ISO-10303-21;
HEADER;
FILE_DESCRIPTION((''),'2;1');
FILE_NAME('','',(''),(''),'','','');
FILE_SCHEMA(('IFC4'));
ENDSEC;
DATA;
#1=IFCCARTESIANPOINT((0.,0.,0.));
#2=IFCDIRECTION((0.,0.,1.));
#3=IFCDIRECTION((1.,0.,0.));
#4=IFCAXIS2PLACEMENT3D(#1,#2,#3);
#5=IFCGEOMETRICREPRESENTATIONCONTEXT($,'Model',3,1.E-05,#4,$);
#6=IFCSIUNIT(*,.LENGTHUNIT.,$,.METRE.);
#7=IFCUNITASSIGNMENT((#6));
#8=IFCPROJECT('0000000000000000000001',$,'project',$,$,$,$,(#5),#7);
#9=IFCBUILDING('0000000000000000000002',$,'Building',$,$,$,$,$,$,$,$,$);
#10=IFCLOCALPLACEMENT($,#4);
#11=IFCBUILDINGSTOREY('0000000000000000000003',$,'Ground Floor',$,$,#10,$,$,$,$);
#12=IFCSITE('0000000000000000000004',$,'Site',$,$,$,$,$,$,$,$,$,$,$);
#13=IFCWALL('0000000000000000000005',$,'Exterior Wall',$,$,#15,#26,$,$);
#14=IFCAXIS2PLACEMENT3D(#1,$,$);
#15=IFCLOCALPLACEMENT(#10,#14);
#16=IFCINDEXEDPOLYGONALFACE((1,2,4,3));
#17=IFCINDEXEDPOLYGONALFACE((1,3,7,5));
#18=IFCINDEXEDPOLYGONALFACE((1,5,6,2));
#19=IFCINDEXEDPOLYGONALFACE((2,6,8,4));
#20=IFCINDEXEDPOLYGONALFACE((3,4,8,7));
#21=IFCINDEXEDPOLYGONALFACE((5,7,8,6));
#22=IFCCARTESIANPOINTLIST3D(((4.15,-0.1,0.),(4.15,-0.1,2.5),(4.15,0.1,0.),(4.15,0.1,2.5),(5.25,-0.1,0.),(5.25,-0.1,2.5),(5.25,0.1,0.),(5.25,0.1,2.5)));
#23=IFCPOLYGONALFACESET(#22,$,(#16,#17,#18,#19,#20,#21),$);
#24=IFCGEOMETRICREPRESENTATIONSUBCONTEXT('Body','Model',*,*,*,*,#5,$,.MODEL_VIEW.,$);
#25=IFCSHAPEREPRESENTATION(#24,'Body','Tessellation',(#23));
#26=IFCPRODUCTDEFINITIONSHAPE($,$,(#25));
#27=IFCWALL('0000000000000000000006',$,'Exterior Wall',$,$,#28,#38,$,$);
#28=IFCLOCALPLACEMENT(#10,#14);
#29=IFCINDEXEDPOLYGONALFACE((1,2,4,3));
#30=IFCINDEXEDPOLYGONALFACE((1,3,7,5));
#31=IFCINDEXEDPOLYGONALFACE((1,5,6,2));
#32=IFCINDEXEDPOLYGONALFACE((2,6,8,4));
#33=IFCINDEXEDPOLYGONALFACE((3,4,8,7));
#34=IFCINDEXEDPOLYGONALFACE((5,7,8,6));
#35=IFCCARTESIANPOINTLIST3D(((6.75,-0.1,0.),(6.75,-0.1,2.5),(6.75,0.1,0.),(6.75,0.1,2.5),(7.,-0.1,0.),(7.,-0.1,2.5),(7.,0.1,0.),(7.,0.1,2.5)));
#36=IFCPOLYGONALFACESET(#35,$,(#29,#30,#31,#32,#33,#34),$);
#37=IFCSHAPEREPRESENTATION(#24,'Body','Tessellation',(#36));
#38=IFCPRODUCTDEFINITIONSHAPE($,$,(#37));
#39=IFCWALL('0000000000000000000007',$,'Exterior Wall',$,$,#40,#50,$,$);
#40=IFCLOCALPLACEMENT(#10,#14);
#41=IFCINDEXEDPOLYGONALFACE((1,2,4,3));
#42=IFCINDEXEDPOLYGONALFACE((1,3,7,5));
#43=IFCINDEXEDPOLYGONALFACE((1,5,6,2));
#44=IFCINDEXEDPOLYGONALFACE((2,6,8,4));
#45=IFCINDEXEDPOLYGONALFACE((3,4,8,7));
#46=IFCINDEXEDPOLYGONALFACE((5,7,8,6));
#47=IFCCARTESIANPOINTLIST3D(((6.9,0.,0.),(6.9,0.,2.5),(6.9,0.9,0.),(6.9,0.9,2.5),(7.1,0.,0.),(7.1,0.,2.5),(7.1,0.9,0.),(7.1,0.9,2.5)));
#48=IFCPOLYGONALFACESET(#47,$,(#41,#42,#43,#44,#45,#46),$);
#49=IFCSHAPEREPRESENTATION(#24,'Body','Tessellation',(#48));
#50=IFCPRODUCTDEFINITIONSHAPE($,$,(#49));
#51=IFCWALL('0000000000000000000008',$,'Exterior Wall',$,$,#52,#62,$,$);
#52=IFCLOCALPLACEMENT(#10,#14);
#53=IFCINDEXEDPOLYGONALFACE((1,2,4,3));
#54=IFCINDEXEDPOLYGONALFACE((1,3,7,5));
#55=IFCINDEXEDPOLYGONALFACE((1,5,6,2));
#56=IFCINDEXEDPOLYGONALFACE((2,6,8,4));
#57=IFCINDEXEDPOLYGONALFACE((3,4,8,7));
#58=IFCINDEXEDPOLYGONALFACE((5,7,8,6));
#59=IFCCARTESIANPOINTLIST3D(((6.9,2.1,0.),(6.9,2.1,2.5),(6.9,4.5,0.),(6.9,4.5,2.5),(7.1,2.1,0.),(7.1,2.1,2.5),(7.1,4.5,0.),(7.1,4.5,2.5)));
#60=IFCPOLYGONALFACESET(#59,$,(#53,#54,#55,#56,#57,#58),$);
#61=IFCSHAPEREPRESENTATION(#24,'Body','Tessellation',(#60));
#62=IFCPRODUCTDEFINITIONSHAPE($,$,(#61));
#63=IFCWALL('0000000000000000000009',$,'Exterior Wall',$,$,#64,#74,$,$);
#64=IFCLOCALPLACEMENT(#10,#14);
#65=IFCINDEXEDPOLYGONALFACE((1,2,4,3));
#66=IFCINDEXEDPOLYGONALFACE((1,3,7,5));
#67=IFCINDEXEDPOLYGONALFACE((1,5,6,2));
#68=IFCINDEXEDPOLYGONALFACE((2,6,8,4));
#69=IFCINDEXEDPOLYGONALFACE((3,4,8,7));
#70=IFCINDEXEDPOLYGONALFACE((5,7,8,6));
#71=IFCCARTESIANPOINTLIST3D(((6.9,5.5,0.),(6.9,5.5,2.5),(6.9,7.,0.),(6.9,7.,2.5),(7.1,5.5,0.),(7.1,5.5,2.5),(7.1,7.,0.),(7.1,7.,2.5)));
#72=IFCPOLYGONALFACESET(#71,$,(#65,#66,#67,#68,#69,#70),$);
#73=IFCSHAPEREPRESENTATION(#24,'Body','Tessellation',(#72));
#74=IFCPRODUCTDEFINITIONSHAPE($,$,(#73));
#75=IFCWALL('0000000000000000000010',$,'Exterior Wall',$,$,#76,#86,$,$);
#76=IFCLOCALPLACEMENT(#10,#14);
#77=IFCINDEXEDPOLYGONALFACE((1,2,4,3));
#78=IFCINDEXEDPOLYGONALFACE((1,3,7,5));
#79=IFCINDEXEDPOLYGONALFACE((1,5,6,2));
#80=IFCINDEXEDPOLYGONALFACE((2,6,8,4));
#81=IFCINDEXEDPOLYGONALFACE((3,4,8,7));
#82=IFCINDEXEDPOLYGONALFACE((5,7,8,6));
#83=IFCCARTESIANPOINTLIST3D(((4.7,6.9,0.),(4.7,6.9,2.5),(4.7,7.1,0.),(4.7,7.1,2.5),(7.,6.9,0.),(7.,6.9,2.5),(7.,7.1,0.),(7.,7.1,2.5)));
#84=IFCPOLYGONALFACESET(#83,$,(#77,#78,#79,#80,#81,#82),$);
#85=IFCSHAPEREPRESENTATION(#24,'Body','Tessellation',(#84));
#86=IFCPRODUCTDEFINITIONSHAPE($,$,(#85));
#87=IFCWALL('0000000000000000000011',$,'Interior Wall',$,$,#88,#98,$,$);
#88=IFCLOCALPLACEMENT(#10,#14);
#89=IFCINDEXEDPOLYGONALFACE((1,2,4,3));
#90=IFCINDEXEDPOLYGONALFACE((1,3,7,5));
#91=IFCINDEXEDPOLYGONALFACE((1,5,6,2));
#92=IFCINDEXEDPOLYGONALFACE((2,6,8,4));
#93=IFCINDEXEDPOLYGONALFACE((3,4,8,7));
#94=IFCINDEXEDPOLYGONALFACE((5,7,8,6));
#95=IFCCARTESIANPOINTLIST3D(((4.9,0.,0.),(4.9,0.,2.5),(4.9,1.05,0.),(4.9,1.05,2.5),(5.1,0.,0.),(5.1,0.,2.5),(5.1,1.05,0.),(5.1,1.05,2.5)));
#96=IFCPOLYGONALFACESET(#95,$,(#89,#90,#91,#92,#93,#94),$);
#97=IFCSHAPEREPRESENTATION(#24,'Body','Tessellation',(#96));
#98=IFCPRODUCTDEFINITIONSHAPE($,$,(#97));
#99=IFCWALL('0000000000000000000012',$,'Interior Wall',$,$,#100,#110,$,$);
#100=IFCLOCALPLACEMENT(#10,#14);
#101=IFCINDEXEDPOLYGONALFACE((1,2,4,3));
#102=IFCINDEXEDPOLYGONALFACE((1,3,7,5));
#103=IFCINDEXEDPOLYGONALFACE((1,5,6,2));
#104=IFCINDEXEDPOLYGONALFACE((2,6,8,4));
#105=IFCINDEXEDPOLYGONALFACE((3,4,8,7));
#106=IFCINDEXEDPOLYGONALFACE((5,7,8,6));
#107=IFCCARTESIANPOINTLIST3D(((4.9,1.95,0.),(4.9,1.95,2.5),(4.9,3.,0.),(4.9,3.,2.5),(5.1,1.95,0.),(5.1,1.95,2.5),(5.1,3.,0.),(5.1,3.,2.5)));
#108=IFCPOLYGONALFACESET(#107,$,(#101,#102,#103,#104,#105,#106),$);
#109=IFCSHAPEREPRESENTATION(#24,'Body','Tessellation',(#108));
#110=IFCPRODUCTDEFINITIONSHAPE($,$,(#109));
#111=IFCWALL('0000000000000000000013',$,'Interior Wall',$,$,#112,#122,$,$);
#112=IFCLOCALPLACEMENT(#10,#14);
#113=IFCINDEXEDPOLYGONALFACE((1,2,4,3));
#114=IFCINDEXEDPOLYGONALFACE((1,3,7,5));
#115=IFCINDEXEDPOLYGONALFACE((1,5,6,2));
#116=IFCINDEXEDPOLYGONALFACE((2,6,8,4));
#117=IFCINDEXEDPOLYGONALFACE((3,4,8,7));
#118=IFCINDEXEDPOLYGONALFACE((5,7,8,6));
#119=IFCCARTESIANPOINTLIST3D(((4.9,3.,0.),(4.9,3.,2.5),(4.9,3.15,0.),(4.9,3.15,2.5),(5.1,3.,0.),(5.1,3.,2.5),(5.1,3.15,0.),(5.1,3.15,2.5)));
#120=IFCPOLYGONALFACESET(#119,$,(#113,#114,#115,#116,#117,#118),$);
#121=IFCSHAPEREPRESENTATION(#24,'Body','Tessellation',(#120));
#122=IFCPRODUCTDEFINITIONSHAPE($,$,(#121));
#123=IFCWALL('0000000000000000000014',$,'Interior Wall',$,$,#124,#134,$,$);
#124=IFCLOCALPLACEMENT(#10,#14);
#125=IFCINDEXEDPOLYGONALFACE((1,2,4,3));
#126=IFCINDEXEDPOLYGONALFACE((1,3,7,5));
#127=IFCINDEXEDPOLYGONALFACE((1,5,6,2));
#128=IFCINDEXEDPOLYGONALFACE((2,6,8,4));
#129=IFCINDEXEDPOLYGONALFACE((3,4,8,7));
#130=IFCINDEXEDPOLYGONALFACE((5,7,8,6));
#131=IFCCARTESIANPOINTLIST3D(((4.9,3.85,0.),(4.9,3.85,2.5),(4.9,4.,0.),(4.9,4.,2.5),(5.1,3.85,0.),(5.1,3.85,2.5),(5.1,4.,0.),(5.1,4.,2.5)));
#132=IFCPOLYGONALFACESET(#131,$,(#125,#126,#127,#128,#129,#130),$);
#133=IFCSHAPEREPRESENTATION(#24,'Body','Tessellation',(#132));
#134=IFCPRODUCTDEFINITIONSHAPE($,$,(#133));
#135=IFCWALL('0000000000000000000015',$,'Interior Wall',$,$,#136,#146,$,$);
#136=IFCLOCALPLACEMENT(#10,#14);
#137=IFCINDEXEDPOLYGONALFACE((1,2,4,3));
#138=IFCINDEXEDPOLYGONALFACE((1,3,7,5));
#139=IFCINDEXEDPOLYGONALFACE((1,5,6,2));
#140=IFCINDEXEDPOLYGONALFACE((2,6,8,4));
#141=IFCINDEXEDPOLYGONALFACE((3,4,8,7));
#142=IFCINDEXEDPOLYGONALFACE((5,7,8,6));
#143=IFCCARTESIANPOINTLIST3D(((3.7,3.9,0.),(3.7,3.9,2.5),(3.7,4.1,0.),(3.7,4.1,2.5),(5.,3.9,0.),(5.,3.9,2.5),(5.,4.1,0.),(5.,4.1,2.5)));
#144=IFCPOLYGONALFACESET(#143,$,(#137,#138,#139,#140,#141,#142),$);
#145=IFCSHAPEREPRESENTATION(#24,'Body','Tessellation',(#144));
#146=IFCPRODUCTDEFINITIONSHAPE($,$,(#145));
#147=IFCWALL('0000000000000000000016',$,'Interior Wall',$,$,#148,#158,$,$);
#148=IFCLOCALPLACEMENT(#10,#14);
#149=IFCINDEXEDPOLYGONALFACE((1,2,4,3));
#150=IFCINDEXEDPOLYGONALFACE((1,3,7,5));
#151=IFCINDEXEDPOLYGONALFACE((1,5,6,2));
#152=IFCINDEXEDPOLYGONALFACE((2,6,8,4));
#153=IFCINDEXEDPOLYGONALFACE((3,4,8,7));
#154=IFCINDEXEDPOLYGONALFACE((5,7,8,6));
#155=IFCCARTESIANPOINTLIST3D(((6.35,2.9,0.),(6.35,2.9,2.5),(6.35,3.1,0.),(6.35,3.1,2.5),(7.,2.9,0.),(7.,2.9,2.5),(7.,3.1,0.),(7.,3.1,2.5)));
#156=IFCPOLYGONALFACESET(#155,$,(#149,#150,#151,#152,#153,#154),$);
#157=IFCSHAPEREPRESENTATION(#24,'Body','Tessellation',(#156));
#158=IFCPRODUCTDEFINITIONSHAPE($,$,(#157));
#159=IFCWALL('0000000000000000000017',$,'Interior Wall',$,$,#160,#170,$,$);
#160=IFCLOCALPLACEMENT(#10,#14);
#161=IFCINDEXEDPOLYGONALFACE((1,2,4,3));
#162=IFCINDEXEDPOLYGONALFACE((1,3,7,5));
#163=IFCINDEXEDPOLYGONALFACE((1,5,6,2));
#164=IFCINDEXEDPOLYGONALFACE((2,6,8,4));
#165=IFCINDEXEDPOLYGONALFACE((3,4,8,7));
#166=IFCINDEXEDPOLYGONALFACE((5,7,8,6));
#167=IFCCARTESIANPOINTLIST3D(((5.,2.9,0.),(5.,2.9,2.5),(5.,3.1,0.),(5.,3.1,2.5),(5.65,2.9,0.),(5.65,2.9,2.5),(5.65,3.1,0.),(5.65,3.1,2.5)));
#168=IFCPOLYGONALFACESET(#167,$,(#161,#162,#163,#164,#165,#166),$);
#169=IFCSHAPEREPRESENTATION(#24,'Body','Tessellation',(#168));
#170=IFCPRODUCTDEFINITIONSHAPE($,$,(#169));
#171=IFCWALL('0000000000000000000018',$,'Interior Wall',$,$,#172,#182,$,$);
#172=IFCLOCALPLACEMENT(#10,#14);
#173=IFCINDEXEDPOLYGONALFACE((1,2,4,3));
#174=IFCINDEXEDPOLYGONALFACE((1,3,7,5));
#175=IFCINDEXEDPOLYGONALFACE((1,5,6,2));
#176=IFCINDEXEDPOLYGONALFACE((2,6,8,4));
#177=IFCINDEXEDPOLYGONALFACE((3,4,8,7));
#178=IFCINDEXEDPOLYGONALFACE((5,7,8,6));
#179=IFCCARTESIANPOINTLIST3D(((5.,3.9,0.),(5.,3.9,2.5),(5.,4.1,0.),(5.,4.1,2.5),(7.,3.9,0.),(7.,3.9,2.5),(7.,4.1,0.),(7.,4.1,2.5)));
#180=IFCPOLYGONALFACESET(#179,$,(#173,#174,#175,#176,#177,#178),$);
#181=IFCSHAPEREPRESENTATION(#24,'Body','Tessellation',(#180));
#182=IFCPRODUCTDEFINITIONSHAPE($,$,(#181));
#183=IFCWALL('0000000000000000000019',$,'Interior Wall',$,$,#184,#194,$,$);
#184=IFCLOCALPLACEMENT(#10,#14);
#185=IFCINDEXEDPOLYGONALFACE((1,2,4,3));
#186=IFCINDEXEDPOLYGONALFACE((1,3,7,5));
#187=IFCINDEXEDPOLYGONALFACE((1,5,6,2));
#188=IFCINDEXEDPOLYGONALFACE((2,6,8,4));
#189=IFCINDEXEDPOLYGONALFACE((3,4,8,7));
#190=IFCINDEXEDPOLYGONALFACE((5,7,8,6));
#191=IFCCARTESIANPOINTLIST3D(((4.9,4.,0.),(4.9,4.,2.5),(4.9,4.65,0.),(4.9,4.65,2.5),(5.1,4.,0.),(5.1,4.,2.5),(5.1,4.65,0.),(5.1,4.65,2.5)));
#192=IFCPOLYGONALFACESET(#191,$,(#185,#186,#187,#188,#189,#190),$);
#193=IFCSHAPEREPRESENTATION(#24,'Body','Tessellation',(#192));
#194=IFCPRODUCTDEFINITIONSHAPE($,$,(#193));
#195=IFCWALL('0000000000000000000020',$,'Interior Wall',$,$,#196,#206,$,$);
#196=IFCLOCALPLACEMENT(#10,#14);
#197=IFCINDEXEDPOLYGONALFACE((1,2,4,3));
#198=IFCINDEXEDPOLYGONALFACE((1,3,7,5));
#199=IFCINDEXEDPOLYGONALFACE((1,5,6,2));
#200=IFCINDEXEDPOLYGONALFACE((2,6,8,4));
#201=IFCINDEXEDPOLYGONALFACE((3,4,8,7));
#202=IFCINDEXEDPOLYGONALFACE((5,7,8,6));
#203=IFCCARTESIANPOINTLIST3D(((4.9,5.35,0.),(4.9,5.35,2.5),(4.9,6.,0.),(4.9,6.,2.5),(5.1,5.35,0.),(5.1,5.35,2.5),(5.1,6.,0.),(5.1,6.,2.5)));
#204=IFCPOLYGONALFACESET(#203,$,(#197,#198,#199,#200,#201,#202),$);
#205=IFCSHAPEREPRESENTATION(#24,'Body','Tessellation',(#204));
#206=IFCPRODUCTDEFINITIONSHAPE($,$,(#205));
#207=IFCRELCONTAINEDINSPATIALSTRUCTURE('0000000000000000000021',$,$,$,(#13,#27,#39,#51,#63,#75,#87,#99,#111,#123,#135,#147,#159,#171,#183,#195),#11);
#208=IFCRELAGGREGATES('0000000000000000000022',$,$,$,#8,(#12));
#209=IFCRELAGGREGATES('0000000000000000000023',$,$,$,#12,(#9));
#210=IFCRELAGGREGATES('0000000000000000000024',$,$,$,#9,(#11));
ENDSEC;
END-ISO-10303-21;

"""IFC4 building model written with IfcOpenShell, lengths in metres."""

from ifc_helpers import new_model, si_unit, frame, origin_with_axes, place, context, subcontext, project, spatial, indexed_curve, outline, extrude, element, save


model = new_model("IFC4")

# Units and contexts
model_context = context("Model", 3, precision=1e-05, world=origin_with_axes())
body_context = subcontext(model_context, "Body", "Model", "MODEL_VIEW")
ifc_project = project(units=[si_unit("LENGTHUNIT", "METRE")], contexts=[model_context])

# Site, building, storey
site = spatial("IfcSite", under=ifc_project, Name="Site")
building = spatial("IfcBuilding", under=site, Name="Building")
storey_placement = place(None, origin_with_axes())
storey = spatial("IfcBuildingStorey", under=building, at=storey_placement, Name="Ground Floor")

# Walls
wall_1_placement = place(storey_placement, frame((4.15, 0.0, 0.0), z_axis=(0.0, 0.0, 1.0), x_axis=(1.0, 0.0, 0.0)))
element("IfcWall", 1, at=wall_1_placement, inside=storey, Name="Exterior Wall", context=body_context, shape_type="SweptSolid", body=[
    extrude(outline(indexed_curve([(0.0, 0.0), (0.0, 0.2), (1.1, 0.2), (1.1, 0.0), (0.0, 0.0)], self_intersect=False)), frame((0.0, -0.1, 0.0), z_axis=(0.0, 0.0, 1.0), x_axis=(1.0, 0.0, 0.0)), (0.0, 0.0, 1.0), 2.5),
])
wall_2_placement = place(storey_placement, frame((6.75, 0.0, 0.0), z_axis=(0.0, 0.0, 1.0), x_axis=(1.0, 0.0, 0.0)))
element("IfcWall", 2, at=wall_2_placement, inside=storey, Name="Exterior Wall", context=body_context, shape_type="SweptSolid", body=[
    extrude(outline(indexed_curve([(0.0, 0.0), (0.0, 0.2), (0.25, 0.2), (0.25, 0.0), (0.0, 0.0)], self_intersect=False)), frame((0.0, -0.1, 0.0), z_axis=(0.0, 0.0, 1.0), x_axis=(1.0, 0.0, 0.0)), (0.0, 0.0, 1.0), 2.5),
])
wall_3_placement = place(storey_placement, frame((7.0, 0.0, 0.0), z_axis=(0.0, 0.0, 1.0), x_axis=(0.0, 1.0, 0.0)))
element("IfcWall", 3, at=wall_3_placement, inside=storey, Name="Exterior Wall", context=body_context, shape_type="SweptSolid", body=[
    extrude(outline(indexed_curve([(0.0, 0.0), (0.0, 0.2), (0.9, 0.2), (0.9, 0.0), (0.0, 0.0)], self_intersect=False)), frame((0.0, -0.1, 0.0), z_axis=(0.0, 0.0, 1.0), x_axis=(1.0, 0.0, 0.0)), (0.0, 0.0, 1.0), 2.5),
])
wall_4_placement = place(storey_placement, frame((7.0, 2.1, 0.0), z_axis=(0.0, 0.0, 1.0), x_axis=(0.0, 1.0, 0.0)))
element("IfcWall", 4, at=wall_4_placement, inside=storey, Name="Exterior Wall", context=body_context, shape_type="SweptSolid", body=[
    extrude(outline(indexed_curve([(0.0, 0.0), (0.0, 0.2), (2.4, 0.2), (2.4, 0.0), (0.0, 0.0)], self_intersect=False)), frame((0.0, -0.1, 0.0), z_axis=(0.0, 0.0, 1.0), x_axis=(1.0, 0.0, 0.0)), (0.0, 0.0, 1.0), 2.5),
])
wall_5_placement = place(storey_placement, frame((7.0, 5.5, 0.0), z_axis=(0.0, 0.0, 1.0), x_axis=(0.0, 1.0, 0.0)))
element("IfcWall", 5, at=wall_5_placement, inside=storey, Name="Exterior Wall", context=body_context, shape_type="SweptSolid", body=[
    extrude(outline(indexed_curve([(0.0, 0.0), (0.0, 0.2), (1.5, 0.2), (1.5, 0.0), (0.0, 0.0)], self_intersect=False)), frame((0.0, -0.1, 0.0), z_axis=(0.0, 0.0, 1.0), x_axis=(1.0, 0.0, 0.0)), (0.0, 0.0, 1.0), 2.5),
])
wall_6_placement = place(storey_placement, frame((7.0, 7.0, 0.0), z_axis=(0.0, 0.0, 1.0), x_axis=(-1.0, 0.0, 0.0)))
element("IfcWall", 6, at=wall_6_placement, inside=storey, Name="Exterior Wall", context=body_context, shape_type="SweptSolid", body=[
    extrude(outline(indexed_curve([(0.0, 0.0), (0.0, 0.2), (2.3, 0.2), (2.3, 0.0), (0.0, 0.0)], self_intersect=False)), frame((0.0, -0.1, 0.0), z_axis=(0.0, 0.0, 1.0), x_axis=(1.0, 0.0, 0.0)), (0.0, 0.0, 1.0), 2.5),
])
for number, where, z_axis, x_axis, name in (
    (7, (5.0, 0.0, 0.0), (0.0, 0.0, 1.0), (0.0, 1.0, 0.0), "Interior Wall"),
    (8, (5.0, 1.95, 0.0), (0.0, 0.0, 1.0), (0.0, 1.0, 0.0), "Interior Wall"),
):
    element("IfcWall", number, at=place(storey_placement, frame(where, z_axis=z_axis, x_axis=x_axis)), inside=storey, Name=name, context=body_context, shape_type="SweptSolid", body=[
        extrude(outline(indexed_curve([(0.0, 0.0), (0.0, 0.2), (1.05, 0.2), (1.05, 0.0), (0.0, 0.0)], self_intersect=False)), frame((0.0, -0.1, 0.0), z_axis=(0.0, 0.0, 1.0), x_axis=(1.0, 0.0, 0.0)), (0.0, 0.0, 1.0), 2.5),
    ])
for number, where, z_axis, x_axis, name in (
    (9, (5.0, 3.0, 0.0), (0.0, 0.0, 1.0), (0.0, 1.0, 0.0), "Interior Wall"),
    (10, (5.0, 3.85, 0.0), (0.0, 0.0, 1.0), (0.0, 1.0, 0.0), "Interior Wall"),
):
    element("IfcWall", number, at=place(storey_placement, frame(where, z_axis=z_axis, x_axis=x_axis)), inside=storey, Name=name, context=body_context, shape_type="SweptSolid", body=[
        extrude(outline(indexed_curve([(0.0, 0.0), (0.0, 0.2), (0.15, 0.2), (0.15, 0.0), (0.0, 0.0)], self_intersect=False)), frame((0.0, -0.1, 0.0), z_axis=(0.0, 0.0, 1.0), x_axis=(1.0, 0.0, 0.0)), (0.0, 0.0, 1.0), 2.5),
    ])
wall_7_placement = place(storey_placement, frame((5.0, 4.0, 0.0), z_axis=(0.0, 0.0, 1.0), x_axis=(-1.0, 0.0, 0.0)))
element("IfcWall", 11, at=wall_7_placement, inside=storey, Name="Interior Wall", context=body_context, shape_type="SweptSolid", body=[
    extrude(outline(indexed_curve([(0.0, 0.0), (0.0, 0.2), (1.3, 0.2), (1.3, 0.0), (0.0, 0.0)], self_intersect=False)), frame((0.0, -0.1, 0.0), z_axis=(0.0, 0.0, 1.0), x_axis=(1.0, 0.0, 0.0)), (0.0, 0.0, 1.0), 2.5),
])
for number, where, z_axis, x_axis, name in (
    (12, (7.0, 3.0, 0.0), (0.0, 0.0, 1.0), (-1.0, 0.0, 0.0), "Interior Wall"),
    (13, (5.65, 3.0, 0.0), (0.0, 0.0, 1.0), (-1.0, 0.0, 0.0), "Interior Wall"),
):
    element("IfcWall", number, at=place(storey_placement, frame(where, z_axis=z_axis, x_axis=x_axis)), inside=storey, Name=name, context=body_context, shape_type="SweptSolid", body=[
        extrude(outline(indexed_curve([(0.0, 0.0), (0.0, 0.2), (0.65, 0.2), (0.65, 0.0), (0.0, 0.0)], self_intersect=False)), frame((0.0, -0.1, 0.0), z_axis=(0.0, 0.0, 1.0), x_axis=(1.0, 0.0, 0.0)), (0.0, 0.0, 1.0), 2.5),
    ])
wall_8_placement = place(storey_placement, frame((7.0, 4.0, 0.0), z_axis=(0.0, 0.0, 1.0), x_axis=(-1.0, 0.0, 0.0)))
element("IfcWall", 14, at=wall_8_placement, inside=storey, Name="Interior Wall", context=body_context, shape_type="SweptSolid", body=[
    extrude(outline(indexed_curve([(0.0, 0.0), (0.0, 0.2), (2.0, 0.2), (2.0, 0.0), (0.0, 0.0)], self_intersect=False)), frame((0.0, -0.1, 0.0), z_axis=(0.0, 0.0, 1.0), x_axis=(1.0, 0.0, 0.0)), (0.0, 0.0, 1.0), 2.5),
])
for number, where, z_axis, x_axis, name in (
    (15, (5.0, 4.0, 0.0), (0.0, 0.0, 1.0), (0.0, 1.0, 0.0), "Interior Wall"),
    (16, (5.0, 5.35, 0.0), (0.0, 0.0, 1.0), (0.0, 1.0, 0.0), "Interior Wall"),
):
    element("IfcWall", number, at=place(storey_placement, frame(where, z_axis=z_axis, x_axis=x_axis)), inside=storey, Name=name, context=body_context, shape_type="SweptSolid", body=[
        extrude(outline(indexed_curve([(0.0, 0.0), (0.0, 0.2), (0.65, 0.2), (0.65, 0.0), (0.0, 0.0)], self_intersect=False)), frame((0.0, -0.1, 0.0), z_axis=(0.0, 0.0, 1.0), x_axis=(1.0, 0.0, 0.0)), (0.0, 0.0, 1.0), 2.5),
    ])

save(model, "model.ifc")
